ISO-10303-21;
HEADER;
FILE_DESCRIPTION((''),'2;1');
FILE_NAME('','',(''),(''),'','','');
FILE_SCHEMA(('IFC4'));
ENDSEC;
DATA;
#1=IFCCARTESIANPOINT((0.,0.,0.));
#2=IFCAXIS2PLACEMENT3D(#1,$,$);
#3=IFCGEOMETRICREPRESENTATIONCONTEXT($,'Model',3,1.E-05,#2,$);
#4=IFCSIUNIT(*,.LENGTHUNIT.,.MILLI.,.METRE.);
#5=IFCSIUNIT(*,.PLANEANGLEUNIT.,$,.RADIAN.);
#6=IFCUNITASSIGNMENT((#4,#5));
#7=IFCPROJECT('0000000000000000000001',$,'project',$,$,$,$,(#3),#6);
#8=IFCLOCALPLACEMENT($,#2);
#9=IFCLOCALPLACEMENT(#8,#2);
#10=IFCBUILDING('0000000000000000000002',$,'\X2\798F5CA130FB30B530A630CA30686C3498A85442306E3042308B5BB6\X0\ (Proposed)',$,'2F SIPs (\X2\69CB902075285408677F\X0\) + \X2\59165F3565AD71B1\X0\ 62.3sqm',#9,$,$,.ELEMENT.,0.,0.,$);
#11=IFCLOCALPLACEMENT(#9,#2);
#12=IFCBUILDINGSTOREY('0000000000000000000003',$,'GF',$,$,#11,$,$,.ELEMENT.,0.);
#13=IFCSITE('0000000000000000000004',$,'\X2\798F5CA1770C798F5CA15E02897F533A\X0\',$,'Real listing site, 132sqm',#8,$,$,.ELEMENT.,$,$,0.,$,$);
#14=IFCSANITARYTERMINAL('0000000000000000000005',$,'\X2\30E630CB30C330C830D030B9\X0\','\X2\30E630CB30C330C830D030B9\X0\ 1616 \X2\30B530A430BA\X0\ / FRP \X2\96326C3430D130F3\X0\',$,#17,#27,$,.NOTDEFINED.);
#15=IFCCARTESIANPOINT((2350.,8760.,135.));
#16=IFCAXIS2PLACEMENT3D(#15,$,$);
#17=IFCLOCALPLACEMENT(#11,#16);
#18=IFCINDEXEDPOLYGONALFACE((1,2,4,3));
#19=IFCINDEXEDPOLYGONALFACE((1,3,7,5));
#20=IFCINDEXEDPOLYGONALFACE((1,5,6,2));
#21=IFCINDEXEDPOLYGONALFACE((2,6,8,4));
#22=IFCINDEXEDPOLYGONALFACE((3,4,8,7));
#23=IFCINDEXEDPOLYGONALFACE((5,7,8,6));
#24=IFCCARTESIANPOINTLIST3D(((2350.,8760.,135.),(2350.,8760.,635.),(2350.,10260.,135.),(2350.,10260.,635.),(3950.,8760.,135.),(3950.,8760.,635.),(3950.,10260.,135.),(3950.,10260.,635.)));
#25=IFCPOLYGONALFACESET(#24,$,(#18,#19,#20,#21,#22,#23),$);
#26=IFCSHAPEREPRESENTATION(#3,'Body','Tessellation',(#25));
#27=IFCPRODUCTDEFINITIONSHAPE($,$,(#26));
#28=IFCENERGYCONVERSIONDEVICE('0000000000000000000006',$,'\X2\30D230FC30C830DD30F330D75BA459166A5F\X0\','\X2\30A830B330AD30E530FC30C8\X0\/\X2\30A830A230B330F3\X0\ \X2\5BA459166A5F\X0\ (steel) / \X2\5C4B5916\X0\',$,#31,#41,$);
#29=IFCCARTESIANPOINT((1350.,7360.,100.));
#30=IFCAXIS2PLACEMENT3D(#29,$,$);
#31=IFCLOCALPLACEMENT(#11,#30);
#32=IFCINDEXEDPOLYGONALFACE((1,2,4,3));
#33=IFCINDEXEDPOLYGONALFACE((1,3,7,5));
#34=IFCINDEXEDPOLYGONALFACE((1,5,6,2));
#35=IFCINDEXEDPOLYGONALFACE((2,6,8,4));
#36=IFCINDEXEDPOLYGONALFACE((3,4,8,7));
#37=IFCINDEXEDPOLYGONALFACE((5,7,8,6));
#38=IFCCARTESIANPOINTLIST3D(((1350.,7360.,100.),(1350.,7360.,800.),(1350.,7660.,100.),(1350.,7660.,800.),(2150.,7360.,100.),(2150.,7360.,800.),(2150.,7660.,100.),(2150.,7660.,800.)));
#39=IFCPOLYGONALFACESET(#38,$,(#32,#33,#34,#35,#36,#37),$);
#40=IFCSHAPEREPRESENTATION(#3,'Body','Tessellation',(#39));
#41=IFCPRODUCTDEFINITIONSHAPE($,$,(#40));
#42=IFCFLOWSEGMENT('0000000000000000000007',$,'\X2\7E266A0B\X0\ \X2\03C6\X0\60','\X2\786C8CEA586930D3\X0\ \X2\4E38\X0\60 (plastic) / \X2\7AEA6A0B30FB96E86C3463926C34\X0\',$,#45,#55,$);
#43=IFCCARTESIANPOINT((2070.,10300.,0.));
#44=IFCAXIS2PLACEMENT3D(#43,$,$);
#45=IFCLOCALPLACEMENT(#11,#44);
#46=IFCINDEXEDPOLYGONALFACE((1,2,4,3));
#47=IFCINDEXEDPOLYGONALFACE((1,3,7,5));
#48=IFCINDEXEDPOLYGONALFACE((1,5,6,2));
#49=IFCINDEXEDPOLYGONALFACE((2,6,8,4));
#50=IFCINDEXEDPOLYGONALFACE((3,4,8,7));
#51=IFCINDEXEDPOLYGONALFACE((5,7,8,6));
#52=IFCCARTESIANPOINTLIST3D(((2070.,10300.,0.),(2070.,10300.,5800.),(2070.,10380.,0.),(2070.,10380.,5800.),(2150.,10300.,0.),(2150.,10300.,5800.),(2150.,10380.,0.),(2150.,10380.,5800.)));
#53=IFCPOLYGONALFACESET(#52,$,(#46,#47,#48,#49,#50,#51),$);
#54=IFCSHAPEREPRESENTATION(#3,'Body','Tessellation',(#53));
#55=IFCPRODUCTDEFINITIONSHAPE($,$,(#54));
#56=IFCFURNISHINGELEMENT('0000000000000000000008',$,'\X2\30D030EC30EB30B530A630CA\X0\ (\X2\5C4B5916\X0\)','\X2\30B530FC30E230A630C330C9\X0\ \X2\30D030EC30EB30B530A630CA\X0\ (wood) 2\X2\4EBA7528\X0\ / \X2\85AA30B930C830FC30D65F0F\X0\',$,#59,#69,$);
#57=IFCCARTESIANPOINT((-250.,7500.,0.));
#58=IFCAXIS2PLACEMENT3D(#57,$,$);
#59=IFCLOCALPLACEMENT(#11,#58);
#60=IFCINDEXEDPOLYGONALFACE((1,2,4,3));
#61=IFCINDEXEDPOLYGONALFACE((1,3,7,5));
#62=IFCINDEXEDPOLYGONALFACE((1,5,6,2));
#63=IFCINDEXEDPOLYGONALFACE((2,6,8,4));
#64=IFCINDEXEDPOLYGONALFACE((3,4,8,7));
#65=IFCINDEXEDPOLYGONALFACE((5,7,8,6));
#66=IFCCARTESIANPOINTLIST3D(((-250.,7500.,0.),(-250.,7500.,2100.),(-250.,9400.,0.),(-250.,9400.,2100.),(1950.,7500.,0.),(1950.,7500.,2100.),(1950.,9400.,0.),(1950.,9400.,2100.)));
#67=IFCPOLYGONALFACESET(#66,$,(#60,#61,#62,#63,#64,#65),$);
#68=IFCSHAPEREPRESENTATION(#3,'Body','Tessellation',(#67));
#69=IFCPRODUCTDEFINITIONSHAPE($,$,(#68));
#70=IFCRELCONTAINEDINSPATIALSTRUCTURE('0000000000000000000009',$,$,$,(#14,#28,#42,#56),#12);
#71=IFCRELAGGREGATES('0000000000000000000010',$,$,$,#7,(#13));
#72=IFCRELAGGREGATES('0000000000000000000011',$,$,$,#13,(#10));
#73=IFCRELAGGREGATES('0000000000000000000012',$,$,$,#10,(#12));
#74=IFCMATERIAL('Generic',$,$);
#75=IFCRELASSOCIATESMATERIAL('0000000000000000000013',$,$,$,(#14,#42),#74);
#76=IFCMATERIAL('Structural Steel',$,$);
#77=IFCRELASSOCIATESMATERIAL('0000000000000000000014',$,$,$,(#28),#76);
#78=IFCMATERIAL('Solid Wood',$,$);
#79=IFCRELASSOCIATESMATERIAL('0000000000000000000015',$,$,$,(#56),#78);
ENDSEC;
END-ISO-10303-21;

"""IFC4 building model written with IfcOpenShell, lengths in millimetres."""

from ifc_helpers import new_model, si_unit, frame, frame_2d, origin, place, context, project, spatial, rectangle, extrude, material, element, save


model = new_model("IFC4")

# Units and contexts
model_context = context("Model", 3, precision=1e-05, world=origin())
ifc_project = project(units=[si_unit("LENGTHUNIT", "METRE", prefix="MILLI"), si_unit("PLANEANGLEUNIT", "RADIAN")], contexts=[model_context])

# Site, building, storey
site_placement = place(None, origin())
site = spatial("IfcSite", under=ifc_project, at=site_placement, Name="福岡県福岡市西区", ObjectType="Real listing site, 132sqm", CompositionType="ELEMENT", RefElevation=0.0)
building_placement = place(site_placement, origin())
building = spatial("IfcBuilding", under=site, at=building_placement, Name="福岡・サウナと水風呂のある家 (Proposed)", ObjectType="2F SIPs (構造用合板) + 外張断熱 62.3sqm", CompositionType="ELEMENT", ElevationOfRefHeight=0.0, ElevationOfTerrain=0.0)
storey_placement = place(building_placement, origin())
storey = spatial("IfcBuildingStorey", under=building, at=storey_placement, Name="GF", CompositionType="ELEMENT", Elevation=0.0)

# Shared definitions
ifc_material_1 = material(Name="Solid Wood")

# Shared definitions
ifc_material_2 = material(Name="Generic")

# Sanitary terminal
sanitary_terminal_placement = place(storey_placement, frame((2350.0, 8760.0, 135.0)))
element("IfcSanitaryTerminal", 1, at=sanitary_terminal_placement, inside=storey, material=ifc_material_2, Name="ユニットバス", Description="ユニットバス 1616 サイズ / FRP 防水パン", PredefinedType="NOTDEFINED", context=model_context, shape_type="SweptSolid", body=[
    extrude(rectangle(XDim=1600.0, YDim=1500.0, at=frame_2d((800.0, 750.0))), frame((2350.0, 8760.0, 135.0)), (0.0, 0.0, 1.0), 500.0),
])

# Energy conversion device
ifc_material_3 = material(Name="Structural Steel")
energy_conversion_device_placement = place(storey_placement, frame((1350.0, 7360.0, 100.0)))
element("IfcEnergyConversionDevice", 2, at=energy_conversion_device_placement, inside=storey, material=ifc_material_3, Name="ヒートポンプ室外機", Description="エコキュート/エアコン 室外機 (steel) / 屋外", context=model_context, shape_type="SweptSolid", body=[
    extrude(rectangle(XDim=800.0, YDim=300.0, at=frame_2d((400.0, 150.0))), frame((1350.0, 7360.0, 100.0)), (0.0, 0.0, 1.0), 700.0),
])

# Flow segment
flow_segment_placement = place(storey_placement, frame((2070.0, 10300.0, 0.0)))
element("IfcFlowSegment", 3, at=flow_segment_placement, inside=storey, material=ifc_material_2, Name="縦樋 φ60", Description="硬質塩ビ 丸60 (plastic) / 竪樋・雨水排水", context=model_context, shape_type="SweptSolid", body=[
    extrude(rectangle(XDim=80.0, YDim=80.0, at=frame_2d((40.0, 40.0))), frame((2070.0, 10300.0, 0.0)), (0.0, 0.0, 1.0), 5800.0),
])

# Furnishing element
furnishing_placement = place(storey_placement, frame((-250.0, 7500.0, 0.0)))
element("IfcFurnishingElement", 4, at=furnishing_placement, inside=storey, material=ifc_material_1, Name="バレルサウナ (屋外)", Description="サーモウッド バレルサウナ (wood) 2人用 / 薪ストーブ式", context=model_context, shape_type="SweptSolid", body=[
    extrude(rectangle(XDim=2200.0, YDim=1900.0, at=frame_2d((1100.0, 950.0))), frame((-250.0, 7500.0, 0.0)), (0.0, 0.0, 1.0), 2100.0),
])

save(model, "model.ifc")
